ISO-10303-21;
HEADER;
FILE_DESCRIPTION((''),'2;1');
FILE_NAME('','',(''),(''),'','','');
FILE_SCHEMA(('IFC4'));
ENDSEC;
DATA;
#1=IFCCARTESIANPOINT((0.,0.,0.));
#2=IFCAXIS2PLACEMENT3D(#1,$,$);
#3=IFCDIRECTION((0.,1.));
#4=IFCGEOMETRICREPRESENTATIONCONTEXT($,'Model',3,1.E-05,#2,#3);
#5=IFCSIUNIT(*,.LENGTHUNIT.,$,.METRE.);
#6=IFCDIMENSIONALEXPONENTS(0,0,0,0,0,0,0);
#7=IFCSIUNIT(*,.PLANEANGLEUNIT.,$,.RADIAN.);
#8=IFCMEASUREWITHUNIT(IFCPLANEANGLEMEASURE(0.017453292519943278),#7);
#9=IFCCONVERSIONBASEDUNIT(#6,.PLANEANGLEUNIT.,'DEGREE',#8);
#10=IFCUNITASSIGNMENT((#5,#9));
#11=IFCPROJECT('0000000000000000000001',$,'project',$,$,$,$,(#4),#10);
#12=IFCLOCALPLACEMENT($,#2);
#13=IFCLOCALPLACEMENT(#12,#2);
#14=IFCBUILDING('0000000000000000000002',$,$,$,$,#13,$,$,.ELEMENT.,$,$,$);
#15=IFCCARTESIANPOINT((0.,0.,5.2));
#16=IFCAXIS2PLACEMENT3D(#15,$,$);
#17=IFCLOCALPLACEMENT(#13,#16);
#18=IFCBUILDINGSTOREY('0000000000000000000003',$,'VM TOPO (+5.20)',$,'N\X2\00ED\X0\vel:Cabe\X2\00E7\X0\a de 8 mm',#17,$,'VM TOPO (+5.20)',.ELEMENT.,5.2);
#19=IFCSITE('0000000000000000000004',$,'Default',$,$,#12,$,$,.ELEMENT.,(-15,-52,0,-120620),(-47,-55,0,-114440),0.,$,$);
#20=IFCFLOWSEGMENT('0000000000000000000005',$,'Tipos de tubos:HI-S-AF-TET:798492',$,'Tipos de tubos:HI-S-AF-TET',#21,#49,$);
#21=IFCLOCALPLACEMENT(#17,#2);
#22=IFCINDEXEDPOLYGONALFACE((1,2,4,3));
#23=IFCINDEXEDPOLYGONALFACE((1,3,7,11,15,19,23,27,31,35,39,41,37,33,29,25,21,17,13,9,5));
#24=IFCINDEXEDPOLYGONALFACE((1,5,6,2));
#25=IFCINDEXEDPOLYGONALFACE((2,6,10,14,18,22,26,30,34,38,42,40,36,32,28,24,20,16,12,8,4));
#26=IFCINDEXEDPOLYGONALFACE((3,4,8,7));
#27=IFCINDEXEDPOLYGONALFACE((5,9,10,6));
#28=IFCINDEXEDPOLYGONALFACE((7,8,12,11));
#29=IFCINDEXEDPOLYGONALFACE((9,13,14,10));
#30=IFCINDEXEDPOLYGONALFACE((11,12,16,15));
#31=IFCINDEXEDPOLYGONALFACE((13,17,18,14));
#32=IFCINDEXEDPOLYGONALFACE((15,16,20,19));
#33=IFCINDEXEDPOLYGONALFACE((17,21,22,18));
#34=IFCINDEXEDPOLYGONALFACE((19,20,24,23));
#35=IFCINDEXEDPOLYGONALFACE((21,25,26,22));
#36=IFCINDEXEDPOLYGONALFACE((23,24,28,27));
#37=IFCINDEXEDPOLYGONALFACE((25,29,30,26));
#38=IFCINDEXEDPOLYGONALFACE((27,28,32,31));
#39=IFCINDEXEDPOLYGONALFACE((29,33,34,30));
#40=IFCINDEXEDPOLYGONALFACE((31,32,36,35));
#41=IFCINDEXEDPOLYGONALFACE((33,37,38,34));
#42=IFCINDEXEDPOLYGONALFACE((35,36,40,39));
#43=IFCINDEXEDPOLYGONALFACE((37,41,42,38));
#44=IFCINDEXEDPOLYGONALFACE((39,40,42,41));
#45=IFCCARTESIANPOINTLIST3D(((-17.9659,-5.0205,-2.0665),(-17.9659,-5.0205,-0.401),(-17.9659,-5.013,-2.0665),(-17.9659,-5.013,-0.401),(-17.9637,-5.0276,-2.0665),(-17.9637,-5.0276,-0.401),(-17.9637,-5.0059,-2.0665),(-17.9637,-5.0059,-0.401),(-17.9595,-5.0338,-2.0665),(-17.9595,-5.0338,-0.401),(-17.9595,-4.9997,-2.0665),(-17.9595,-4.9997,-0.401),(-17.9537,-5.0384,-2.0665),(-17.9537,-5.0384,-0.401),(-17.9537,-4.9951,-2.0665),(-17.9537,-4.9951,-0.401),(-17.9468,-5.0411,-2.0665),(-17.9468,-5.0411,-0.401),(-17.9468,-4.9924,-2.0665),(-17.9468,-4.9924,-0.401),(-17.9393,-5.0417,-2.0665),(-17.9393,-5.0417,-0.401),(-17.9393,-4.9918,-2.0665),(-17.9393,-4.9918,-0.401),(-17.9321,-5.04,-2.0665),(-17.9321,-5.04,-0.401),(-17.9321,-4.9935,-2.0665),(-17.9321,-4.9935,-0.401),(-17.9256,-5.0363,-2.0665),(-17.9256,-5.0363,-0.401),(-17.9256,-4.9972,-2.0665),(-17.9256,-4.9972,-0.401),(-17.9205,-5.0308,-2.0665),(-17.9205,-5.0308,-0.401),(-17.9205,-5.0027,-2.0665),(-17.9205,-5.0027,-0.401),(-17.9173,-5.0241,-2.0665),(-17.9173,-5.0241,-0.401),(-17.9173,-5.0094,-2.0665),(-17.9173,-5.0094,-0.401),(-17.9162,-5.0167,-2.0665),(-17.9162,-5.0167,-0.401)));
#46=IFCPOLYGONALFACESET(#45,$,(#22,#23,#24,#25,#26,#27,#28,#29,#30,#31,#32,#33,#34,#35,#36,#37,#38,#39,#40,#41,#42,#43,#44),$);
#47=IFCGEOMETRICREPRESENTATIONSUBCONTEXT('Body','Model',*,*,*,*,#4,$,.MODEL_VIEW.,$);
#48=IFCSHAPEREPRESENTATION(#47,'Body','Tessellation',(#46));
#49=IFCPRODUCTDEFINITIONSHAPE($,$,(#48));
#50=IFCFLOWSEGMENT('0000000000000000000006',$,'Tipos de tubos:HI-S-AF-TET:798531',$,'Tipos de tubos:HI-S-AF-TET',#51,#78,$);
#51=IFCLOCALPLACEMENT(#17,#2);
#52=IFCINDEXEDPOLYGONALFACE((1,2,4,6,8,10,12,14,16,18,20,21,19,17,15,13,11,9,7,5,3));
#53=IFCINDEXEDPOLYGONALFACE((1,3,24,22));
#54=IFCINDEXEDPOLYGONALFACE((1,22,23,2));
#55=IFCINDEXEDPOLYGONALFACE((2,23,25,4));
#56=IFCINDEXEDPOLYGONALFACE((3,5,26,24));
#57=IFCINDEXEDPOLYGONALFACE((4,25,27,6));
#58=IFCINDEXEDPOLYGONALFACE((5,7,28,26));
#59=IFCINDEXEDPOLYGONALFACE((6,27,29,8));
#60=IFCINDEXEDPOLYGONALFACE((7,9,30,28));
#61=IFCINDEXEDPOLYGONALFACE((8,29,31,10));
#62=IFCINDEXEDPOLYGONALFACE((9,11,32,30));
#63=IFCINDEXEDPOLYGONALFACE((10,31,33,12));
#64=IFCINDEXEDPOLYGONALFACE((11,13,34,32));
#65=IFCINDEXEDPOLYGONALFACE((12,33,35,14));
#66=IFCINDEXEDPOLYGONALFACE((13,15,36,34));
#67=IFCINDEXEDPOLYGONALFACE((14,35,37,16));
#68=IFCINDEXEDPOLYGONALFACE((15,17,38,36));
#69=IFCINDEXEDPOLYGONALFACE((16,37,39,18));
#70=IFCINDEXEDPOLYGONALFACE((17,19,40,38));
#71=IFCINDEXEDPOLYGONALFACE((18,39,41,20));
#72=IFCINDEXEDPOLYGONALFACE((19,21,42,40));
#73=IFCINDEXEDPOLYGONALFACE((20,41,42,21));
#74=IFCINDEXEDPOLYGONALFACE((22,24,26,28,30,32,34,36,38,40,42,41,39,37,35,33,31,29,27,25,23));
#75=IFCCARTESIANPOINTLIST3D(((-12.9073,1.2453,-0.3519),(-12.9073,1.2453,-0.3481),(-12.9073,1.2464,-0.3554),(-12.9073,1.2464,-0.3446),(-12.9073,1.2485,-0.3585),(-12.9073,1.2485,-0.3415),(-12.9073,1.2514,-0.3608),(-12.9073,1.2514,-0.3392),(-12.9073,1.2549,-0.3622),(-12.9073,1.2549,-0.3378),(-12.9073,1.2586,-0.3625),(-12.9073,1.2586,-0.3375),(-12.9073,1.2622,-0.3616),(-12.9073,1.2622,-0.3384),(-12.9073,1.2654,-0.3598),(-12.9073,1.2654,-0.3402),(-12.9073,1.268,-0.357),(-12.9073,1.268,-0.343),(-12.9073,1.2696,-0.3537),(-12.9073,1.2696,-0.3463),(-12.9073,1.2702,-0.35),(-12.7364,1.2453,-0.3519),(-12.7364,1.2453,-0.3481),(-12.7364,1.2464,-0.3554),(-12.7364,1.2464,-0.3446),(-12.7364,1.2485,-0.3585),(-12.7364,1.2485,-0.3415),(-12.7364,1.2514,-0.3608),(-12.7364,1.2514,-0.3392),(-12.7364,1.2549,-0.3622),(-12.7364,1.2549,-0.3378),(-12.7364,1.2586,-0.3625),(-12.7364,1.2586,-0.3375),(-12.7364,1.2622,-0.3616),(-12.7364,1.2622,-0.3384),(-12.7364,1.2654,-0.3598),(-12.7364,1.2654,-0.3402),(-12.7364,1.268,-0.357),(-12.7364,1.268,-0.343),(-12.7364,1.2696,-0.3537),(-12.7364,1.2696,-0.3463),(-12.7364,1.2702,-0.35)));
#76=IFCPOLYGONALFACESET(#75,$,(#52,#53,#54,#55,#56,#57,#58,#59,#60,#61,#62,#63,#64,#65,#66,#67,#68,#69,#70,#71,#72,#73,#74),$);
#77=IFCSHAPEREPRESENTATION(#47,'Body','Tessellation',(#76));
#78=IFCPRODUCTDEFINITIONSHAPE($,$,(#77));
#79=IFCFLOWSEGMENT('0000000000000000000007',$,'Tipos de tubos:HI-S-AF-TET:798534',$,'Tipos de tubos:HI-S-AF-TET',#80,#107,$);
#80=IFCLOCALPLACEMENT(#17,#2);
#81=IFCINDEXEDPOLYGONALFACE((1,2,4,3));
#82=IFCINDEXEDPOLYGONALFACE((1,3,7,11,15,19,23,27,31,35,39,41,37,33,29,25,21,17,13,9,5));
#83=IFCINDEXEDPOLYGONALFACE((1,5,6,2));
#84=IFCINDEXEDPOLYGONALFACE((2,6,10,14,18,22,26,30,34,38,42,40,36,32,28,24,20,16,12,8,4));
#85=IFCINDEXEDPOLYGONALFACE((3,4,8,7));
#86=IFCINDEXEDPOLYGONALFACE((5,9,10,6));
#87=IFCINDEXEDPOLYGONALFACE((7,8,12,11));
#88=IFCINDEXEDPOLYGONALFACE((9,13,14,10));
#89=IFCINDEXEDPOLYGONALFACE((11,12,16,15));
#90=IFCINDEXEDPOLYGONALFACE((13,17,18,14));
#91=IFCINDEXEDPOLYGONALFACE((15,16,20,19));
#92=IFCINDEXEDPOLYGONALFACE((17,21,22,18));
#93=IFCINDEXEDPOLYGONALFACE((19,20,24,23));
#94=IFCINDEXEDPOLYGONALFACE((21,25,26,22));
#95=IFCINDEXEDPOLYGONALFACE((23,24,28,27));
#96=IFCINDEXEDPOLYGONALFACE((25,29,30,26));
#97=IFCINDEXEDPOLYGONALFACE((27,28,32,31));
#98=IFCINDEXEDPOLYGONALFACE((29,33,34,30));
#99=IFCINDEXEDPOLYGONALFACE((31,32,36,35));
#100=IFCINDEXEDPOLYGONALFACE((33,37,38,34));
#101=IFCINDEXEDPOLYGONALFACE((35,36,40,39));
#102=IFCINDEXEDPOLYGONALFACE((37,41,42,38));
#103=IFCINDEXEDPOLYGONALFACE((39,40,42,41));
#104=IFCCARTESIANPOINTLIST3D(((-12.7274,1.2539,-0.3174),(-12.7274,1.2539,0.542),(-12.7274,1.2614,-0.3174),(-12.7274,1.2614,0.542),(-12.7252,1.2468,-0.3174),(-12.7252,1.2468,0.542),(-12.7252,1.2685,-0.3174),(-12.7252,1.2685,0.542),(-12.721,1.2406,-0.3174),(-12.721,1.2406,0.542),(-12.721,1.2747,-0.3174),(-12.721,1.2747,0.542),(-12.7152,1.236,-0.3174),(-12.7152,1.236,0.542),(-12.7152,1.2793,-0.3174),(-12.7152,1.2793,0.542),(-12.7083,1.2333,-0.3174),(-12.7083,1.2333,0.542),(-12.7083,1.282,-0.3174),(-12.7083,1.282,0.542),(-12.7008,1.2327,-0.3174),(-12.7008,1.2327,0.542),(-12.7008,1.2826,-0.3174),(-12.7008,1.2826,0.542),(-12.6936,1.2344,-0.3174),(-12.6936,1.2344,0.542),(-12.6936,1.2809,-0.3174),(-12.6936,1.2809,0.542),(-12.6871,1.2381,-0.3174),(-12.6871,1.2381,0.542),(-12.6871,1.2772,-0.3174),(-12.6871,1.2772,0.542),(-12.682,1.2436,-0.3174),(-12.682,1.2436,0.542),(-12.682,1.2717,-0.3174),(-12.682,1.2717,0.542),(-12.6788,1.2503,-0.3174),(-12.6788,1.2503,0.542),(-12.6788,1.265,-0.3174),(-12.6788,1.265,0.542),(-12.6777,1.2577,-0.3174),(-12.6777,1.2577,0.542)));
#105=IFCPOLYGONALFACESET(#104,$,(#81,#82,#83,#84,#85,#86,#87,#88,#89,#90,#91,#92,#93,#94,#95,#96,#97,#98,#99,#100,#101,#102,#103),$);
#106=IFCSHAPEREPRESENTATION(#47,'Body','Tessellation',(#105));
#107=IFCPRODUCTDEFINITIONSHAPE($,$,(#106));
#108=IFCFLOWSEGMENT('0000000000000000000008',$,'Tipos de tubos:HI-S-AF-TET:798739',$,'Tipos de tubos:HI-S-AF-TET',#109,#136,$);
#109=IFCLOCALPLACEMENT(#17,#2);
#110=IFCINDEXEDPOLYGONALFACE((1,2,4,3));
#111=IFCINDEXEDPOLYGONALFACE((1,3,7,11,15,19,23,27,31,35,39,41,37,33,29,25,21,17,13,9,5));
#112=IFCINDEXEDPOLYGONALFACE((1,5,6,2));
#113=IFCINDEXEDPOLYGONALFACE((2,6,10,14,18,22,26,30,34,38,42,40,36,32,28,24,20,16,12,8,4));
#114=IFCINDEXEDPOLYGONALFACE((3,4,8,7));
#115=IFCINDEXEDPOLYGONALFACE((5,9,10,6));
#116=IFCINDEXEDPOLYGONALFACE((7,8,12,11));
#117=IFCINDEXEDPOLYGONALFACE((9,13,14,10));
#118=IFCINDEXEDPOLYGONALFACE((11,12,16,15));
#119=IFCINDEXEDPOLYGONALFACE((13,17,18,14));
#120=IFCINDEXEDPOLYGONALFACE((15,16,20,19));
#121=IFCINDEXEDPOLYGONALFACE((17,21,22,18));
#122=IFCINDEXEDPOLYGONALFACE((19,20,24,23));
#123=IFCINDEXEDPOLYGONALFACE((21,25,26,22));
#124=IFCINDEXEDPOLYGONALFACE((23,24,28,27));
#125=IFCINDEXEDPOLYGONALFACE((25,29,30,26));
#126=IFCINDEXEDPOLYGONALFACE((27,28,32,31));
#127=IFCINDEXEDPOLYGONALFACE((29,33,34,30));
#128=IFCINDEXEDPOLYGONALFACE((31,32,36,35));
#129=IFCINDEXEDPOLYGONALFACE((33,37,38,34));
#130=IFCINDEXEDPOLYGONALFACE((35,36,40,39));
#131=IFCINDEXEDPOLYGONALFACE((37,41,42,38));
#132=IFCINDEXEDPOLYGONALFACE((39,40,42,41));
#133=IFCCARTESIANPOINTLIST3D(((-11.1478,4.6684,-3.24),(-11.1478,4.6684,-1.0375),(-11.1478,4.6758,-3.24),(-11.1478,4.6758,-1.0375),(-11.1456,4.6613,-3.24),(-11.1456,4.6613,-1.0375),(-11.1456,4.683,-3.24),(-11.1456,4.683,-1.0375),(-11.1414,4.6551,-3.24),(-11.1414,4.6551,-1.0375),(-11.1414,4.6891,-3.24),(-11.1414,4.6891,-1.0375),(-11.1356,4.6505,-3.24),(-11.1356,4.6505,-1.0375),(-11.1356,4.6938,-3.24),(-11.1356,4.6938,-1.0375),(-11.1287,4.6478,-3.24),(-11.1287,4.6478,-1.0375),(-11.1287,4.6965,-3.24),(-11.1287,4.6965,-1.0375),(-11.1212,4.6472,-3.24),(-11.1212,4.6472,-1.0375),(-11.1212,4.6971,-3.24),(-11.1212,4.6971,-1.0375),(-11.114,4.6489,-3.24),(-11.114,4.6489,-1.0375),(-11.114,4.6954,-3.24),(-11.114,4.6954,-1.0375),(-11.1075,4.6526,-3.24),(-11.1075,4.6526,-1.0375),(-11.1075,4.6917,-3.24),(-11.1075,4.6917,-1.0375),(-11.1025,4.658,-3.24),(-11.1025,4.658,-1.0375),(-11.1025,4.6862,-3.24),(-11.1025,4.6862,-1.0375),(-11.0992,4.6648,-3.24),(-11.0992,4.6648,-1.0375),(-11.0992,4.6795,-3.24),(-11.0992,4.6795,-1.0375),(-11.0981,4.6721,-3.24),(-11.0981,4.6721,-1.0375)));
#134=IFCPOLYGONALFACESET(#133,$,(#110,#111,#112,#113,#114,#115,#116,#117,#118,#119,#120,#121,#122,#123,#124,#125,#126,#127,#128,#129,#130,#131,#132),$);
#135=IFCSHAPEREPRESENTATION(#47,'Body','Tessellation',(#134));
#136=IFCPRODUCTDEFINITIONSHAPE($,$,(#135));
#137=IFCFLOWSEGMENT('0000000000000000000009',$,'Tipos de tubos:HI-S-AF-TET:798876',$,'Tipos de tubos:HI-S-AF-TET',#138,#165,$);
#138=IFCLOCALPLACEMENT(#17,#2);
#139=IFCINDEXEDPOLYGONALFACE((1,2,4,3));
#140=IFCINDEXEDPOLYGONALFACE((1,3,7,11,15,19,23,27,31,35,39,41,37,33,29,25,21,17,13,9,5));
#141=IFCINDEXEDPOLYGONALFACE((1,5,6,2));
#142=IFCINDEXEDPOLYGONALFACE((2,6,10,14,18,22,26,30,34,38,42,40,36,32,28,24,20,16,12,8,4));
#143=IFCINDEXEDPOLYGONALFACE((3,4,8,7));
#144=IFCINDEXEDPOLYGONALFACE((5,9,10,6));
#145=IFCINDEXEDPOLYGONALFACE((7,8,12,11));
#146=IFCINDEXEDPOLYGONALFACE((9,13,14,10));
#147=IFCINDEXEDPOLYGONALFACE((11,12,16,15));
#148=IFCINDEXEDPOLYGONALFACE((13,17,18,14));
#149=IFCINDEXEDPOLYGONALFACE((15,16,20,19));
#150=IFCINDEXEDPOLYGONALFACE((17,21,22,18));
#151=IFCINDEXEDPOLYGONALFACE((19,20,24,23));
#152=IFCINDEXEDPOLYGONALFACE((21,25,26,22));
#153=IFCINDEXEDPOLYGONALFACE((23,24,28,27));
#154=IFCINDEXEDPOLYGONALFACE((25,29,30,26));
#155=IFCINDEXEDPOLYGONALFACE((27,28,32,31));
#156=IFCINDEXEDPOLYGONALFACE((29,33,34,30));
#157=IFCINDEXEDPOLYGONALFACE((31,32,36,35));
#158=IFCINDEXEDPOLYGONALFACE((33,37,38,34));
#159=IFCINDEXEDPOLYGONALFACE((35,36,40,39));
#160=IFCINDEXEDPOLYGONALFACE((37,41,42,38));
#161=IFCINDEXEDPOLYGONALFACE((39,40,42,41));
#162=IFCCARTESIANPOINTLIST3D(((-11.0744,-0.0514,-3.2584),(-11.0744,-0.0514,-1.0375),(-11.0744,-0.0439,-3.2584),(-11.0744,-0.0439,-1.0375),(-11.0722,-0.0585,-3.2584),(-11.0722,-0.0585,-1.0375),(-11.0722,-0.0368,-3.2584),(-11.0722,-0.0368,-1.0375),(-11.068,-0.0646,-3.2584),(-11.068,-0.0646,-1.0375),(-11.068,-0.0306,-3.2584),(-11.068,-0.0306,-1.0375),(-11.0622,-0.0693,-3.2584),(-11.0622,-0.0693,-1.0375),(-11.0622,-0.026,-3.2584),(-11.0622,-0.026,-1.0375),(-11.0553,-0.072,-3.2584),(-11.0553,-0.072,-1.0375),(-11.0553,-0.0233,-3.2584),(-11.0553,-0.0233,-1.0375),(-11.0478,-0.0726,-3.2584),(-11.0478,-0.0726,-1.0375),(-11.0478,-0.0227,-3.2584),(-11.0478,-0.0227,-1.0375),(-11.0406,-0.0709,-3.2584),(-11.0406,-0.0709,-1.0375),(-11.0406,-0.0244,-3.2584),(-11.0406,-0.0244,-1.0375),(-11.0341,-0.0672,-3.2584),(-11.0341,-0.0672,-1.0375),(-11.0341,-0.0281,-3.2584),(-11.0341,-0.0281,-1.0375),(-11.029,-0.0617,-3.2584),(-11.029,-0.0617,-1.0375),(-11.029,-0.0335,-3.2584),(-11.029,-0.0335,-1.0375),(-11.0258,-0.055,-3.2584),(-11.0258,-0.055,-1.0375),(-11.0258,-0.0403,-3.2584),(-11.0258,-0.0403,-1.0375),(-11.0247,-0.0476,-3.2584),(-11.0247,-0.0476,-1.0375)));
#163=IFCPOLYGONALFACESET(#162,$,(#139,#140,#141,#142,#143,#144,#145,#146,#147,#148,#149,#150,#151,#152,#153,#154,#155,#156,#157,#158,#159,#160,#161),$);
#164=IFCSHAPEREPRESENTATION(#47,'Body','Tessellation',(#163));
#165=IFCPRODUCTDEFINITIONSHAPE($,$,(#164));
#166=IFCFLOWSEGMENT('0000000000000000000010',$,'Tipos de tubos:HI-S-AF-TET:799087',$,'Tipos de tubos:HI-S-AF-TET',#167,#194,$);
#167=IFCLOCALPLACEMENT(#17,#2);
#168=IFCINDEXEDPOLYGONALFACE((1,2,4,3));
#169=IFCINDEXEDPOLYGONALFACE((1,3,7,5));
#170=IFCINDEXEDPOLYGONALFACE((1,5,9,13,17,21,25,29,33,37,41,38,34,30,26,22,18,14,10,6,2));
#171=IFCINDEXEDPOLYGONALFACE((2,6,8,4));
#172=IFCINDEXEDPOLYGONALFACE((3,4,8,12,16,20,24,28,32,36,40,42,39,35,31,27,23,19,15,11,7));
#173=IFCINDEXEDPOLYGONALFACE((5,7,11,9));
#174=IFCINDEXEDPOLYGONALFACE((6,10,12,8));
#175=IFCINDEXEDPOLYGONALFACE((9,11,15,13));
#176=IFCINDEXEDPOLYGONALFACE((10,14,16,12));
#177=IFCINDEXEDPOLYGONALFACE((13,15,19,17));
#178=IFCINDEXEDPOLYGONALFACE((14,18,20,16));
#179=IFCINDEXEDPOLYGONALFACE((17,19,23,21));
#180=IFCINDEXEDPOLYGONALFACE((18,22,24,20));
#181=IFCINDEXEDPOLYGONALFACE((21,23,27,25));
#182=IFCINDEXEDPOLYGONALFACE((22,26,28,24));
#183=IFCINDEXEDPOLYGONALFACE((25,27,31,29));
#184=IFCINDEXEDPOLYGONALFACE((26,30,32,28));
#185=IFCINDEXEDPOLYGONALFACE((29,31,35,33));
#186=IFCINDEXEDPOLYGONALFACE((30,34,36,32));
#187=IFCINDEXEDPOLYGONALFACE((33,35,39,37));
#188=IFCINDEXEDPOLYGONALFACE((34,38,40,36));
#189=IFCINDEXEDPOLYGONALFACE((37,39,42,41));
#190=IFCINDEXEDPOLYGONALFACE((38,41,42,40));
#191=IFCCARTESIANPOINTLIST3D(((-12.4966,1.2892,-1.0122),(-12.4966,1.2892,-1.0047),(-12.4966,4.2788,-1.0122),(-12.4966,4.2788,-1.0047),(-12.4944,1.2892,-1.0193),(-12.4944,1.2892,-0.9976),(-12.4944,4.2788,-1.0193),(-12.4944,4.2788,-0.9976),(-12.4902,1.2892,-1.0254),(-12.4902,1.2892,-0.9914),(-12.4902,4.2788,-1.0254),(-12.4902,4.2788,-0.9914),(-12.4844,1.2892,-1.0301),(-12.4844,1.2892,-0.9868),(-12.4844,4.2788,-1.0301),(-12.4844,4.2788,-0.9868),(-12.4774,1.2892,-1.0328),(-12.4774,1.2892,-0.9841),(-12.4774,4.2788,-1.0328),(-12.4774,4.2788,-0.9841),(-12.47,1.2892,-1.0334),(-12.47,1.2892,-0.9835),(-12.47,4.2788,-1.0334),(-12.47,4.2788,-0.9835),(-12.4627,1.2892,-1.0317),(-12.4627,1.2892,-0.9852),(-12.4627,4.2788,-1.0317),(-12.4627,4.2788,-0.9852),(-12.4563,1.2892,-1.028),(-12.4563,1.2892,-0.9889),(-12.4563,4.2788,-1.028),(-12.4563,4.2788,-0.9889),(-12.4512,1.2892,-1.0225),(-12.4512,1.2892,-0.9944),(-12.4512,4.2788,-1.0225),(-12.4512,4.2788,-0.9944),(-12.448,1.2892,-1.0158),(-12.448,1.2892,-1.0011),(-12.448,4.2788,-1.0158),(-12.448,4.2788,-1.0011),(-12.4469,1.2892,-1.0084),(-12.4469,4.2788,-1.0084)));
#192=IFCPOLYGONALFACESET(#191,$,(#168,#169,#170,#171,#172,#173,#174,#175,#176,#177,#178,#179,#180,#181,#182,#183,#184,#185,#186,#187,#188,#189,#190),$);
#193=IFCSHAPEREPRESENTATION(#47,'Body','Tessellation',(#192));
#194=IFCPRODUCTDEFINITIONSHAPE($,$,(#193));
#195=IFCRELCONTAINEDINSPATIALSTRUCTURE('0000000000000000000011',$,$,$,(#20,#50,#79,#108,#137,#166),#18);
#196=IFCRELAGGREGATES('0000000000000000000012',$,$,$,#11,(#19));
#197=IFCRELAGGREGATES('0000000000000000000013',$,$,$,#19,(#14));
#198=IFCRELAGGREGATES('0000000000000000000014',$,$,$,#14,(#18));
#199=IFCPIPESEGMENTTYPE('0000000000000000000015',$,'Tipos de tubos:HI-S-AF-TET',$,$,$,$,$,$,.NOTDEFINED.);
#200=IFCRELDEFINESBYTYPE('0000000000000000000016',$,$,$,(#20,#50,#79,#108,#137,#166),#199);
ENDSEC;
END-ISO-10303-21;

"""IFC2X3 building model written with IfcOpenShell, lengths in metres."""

from ifc_helpers import new_model, entity, si_unit, converted_unit, direction, frame, frame_2d, origin, origin_2d_with_axis, place, context, subcontext, project, spatial, circle, extrude, type_object, element, save


model = new_model("IFC2X3")

# Units and contexts
model_context = context("Model", 3, precision=1e-05, world=origin(), true_north=direction((0.0, 1.0)))
body_context = subcontext(model_context, "Body", "Model", "MODEL_VIEW")
ifc_project = project(units=[si_unit("LENGTHUNIT", "METRE"), converted_unit("PLANEANGLEUNIT", "DEGREE", entity("IfcPlaneAngleMeasure", 0.017453292519943278), si_unit("PLANEANGLEUNIT", "RADIAN"), dimensions=[0, 0, 0, 0, 0, 0, 0])], contexts=[model_context])

# Site, building, storey
site_placement = place(None, origin())
site = spatial("IfcSite", under=ifc_project, at=site_placement, Name="Default", CompositionType="ELEMENT", RefLatitude=(-15, -52, 0, -120620), RefLongitude=(-47, -55, 0, -114440), RefElevation=0.0)
building_placement = place(site_placement, origin())
building = spatial("IfcBuilding", under=site, at=building_placement, CompositionType="ELEMENT")
storey_placement = place(building_placement, frame((0.0, 0.0, 5.2)))
storey = spatial("IfcBuildingStorey", under=building, at=storey_placement, Name="VM TOPO (+5.20)", ObjectType="Nível:Cabeça de 8 mm", LongName="VM TOPO (+5.20)", CompositionType="ELEMENT", Elevation=5.2)

# Flow segments
pipe_segment_type_1 = type_object("IfcPipeSegmentType", Name="Tipos de tubos:HI-S-AF-TET", PredefinedType="NOTDEFINED")
flow_segment_1_placement = place(storey_placement, origin())
element("IfcFlowSegment", 1, at=flow_segment_1_placement, inside=storey, type_object=pipe_segment_type_1, Name="Tipos de tubos:HI-S-AF-TET:798492", ObjectType="Tipos de tubos:HI-S-AF-TET", context=body_context, shape_type="SweptSolid", body=[
    extrude(circle(Radius=0.025, at=origin_2d_with_axis()), frame((-17.9412, -5.0167, -2.0665)), (0.0, 0.0, 1.0), 1.6655),
])
flow_segment_2_placement = place(storey_placement, origin())
element("IfcFlowSegment", 2, at=flow_segment_2_placement, inside=storey, type_object=pipe_segment_type_1, Name="Tipos de tubos:HI-S-AF-TET:798531", ObjectType="Tipos de tubos:HI-S-AF-TET", context=body_context, shape_type="SweptSolid", body=[
    extrude(circle(Radius=0.0125, at=origin_2d_with_axis()), frame((-12.9073, 1.2577, -0.35), z_axis=(1.0, 0.0, 0.0), x_axis=(0.0, 1.0, 0.0)), (0.0, 0.0, 1.0), 0.1709),
])
flow_segment_3_placement = place(storey_placement, origin())
element("IfcFlowSegment", 3, at=flow_segment_3_placement, inside=storey, type_object=pipe_segment_type_1, Name="Tipos de tubos:HI-S-AF-TET:798534", ObjectType="Tipos de tubos:HI-S-AF-TET", context=body_context, shape_type="SweptSolid", body=[
    extrude(circle(Radius=0.025, at=origin_2d_with_axis()), frame((-12.7027, 1.2577, -0.3174)), (0.0, 0.0, 1.0), 0.8594),
])
flow_segment_4_placement = place(storey_placement, origin())
element("IfcFlowSegment", 4, at=flow_segment_4_placement, inside=storey, type_object=pipe_segment_type_1, Name="Tipos de tubos:HI-S-AF-TET:798739", ObjectType="Tipos de tubos:HI-S-AF-TET", context=body_context, shape_type="SweptSolid", body=[
    extrude(circle(Radius=0.025, at=origin_2d_with_axis()), frame((-11.1231, 4.6721, -3.24)), (0.0, 0.0, 1.0), 2.2025),
])
flow_segment_5_placement = place(storey_placement, origin())
element("IfcFlowSegment", 5, at=flow_segment_5_placement, inside=storey, type_object=pipe_segment_type_1, Name="Tipos de tubos:HI-S-AF-TET:798876", ObjectType="Tipos de tubos:HI-S-AF-TET", context=body_context, shape_type="SweptSolid", body=[
    extrude(circle(Radius=0.025, at=frame_2d((0.0, 0.0), x_axis=(1.0, 0.0))), frame((-11.0497, -0.0476, -3.2584)), (0.0, 0.0, 1.0), 2.2209),
])
flow_segment_6_placement = place(storey_placement, origin())
element("IfcFlowSegment", 6, at=flow_segment_6_placement, inside=storey, type_object=pipe_segment_type_1, Name="Tipos de tubos:HI-S-AF-TET:799087", ObjectType="Tipos de tubos:HI-S-AF-TET", context=body_context, shape_type="SweptSolid", body=[
    extrude(circle(Radius=0.025, at=origin_2d_with_axis()), frame((-12.4719, 1.2892, -1.0084), z_axis=(0.0, 1.0, 0.0), x_axis=(1.0, 0.0, 0.0)), (0.0, 0.0, 1.0), 2.9896),
])

save(model, "model.ifc")
